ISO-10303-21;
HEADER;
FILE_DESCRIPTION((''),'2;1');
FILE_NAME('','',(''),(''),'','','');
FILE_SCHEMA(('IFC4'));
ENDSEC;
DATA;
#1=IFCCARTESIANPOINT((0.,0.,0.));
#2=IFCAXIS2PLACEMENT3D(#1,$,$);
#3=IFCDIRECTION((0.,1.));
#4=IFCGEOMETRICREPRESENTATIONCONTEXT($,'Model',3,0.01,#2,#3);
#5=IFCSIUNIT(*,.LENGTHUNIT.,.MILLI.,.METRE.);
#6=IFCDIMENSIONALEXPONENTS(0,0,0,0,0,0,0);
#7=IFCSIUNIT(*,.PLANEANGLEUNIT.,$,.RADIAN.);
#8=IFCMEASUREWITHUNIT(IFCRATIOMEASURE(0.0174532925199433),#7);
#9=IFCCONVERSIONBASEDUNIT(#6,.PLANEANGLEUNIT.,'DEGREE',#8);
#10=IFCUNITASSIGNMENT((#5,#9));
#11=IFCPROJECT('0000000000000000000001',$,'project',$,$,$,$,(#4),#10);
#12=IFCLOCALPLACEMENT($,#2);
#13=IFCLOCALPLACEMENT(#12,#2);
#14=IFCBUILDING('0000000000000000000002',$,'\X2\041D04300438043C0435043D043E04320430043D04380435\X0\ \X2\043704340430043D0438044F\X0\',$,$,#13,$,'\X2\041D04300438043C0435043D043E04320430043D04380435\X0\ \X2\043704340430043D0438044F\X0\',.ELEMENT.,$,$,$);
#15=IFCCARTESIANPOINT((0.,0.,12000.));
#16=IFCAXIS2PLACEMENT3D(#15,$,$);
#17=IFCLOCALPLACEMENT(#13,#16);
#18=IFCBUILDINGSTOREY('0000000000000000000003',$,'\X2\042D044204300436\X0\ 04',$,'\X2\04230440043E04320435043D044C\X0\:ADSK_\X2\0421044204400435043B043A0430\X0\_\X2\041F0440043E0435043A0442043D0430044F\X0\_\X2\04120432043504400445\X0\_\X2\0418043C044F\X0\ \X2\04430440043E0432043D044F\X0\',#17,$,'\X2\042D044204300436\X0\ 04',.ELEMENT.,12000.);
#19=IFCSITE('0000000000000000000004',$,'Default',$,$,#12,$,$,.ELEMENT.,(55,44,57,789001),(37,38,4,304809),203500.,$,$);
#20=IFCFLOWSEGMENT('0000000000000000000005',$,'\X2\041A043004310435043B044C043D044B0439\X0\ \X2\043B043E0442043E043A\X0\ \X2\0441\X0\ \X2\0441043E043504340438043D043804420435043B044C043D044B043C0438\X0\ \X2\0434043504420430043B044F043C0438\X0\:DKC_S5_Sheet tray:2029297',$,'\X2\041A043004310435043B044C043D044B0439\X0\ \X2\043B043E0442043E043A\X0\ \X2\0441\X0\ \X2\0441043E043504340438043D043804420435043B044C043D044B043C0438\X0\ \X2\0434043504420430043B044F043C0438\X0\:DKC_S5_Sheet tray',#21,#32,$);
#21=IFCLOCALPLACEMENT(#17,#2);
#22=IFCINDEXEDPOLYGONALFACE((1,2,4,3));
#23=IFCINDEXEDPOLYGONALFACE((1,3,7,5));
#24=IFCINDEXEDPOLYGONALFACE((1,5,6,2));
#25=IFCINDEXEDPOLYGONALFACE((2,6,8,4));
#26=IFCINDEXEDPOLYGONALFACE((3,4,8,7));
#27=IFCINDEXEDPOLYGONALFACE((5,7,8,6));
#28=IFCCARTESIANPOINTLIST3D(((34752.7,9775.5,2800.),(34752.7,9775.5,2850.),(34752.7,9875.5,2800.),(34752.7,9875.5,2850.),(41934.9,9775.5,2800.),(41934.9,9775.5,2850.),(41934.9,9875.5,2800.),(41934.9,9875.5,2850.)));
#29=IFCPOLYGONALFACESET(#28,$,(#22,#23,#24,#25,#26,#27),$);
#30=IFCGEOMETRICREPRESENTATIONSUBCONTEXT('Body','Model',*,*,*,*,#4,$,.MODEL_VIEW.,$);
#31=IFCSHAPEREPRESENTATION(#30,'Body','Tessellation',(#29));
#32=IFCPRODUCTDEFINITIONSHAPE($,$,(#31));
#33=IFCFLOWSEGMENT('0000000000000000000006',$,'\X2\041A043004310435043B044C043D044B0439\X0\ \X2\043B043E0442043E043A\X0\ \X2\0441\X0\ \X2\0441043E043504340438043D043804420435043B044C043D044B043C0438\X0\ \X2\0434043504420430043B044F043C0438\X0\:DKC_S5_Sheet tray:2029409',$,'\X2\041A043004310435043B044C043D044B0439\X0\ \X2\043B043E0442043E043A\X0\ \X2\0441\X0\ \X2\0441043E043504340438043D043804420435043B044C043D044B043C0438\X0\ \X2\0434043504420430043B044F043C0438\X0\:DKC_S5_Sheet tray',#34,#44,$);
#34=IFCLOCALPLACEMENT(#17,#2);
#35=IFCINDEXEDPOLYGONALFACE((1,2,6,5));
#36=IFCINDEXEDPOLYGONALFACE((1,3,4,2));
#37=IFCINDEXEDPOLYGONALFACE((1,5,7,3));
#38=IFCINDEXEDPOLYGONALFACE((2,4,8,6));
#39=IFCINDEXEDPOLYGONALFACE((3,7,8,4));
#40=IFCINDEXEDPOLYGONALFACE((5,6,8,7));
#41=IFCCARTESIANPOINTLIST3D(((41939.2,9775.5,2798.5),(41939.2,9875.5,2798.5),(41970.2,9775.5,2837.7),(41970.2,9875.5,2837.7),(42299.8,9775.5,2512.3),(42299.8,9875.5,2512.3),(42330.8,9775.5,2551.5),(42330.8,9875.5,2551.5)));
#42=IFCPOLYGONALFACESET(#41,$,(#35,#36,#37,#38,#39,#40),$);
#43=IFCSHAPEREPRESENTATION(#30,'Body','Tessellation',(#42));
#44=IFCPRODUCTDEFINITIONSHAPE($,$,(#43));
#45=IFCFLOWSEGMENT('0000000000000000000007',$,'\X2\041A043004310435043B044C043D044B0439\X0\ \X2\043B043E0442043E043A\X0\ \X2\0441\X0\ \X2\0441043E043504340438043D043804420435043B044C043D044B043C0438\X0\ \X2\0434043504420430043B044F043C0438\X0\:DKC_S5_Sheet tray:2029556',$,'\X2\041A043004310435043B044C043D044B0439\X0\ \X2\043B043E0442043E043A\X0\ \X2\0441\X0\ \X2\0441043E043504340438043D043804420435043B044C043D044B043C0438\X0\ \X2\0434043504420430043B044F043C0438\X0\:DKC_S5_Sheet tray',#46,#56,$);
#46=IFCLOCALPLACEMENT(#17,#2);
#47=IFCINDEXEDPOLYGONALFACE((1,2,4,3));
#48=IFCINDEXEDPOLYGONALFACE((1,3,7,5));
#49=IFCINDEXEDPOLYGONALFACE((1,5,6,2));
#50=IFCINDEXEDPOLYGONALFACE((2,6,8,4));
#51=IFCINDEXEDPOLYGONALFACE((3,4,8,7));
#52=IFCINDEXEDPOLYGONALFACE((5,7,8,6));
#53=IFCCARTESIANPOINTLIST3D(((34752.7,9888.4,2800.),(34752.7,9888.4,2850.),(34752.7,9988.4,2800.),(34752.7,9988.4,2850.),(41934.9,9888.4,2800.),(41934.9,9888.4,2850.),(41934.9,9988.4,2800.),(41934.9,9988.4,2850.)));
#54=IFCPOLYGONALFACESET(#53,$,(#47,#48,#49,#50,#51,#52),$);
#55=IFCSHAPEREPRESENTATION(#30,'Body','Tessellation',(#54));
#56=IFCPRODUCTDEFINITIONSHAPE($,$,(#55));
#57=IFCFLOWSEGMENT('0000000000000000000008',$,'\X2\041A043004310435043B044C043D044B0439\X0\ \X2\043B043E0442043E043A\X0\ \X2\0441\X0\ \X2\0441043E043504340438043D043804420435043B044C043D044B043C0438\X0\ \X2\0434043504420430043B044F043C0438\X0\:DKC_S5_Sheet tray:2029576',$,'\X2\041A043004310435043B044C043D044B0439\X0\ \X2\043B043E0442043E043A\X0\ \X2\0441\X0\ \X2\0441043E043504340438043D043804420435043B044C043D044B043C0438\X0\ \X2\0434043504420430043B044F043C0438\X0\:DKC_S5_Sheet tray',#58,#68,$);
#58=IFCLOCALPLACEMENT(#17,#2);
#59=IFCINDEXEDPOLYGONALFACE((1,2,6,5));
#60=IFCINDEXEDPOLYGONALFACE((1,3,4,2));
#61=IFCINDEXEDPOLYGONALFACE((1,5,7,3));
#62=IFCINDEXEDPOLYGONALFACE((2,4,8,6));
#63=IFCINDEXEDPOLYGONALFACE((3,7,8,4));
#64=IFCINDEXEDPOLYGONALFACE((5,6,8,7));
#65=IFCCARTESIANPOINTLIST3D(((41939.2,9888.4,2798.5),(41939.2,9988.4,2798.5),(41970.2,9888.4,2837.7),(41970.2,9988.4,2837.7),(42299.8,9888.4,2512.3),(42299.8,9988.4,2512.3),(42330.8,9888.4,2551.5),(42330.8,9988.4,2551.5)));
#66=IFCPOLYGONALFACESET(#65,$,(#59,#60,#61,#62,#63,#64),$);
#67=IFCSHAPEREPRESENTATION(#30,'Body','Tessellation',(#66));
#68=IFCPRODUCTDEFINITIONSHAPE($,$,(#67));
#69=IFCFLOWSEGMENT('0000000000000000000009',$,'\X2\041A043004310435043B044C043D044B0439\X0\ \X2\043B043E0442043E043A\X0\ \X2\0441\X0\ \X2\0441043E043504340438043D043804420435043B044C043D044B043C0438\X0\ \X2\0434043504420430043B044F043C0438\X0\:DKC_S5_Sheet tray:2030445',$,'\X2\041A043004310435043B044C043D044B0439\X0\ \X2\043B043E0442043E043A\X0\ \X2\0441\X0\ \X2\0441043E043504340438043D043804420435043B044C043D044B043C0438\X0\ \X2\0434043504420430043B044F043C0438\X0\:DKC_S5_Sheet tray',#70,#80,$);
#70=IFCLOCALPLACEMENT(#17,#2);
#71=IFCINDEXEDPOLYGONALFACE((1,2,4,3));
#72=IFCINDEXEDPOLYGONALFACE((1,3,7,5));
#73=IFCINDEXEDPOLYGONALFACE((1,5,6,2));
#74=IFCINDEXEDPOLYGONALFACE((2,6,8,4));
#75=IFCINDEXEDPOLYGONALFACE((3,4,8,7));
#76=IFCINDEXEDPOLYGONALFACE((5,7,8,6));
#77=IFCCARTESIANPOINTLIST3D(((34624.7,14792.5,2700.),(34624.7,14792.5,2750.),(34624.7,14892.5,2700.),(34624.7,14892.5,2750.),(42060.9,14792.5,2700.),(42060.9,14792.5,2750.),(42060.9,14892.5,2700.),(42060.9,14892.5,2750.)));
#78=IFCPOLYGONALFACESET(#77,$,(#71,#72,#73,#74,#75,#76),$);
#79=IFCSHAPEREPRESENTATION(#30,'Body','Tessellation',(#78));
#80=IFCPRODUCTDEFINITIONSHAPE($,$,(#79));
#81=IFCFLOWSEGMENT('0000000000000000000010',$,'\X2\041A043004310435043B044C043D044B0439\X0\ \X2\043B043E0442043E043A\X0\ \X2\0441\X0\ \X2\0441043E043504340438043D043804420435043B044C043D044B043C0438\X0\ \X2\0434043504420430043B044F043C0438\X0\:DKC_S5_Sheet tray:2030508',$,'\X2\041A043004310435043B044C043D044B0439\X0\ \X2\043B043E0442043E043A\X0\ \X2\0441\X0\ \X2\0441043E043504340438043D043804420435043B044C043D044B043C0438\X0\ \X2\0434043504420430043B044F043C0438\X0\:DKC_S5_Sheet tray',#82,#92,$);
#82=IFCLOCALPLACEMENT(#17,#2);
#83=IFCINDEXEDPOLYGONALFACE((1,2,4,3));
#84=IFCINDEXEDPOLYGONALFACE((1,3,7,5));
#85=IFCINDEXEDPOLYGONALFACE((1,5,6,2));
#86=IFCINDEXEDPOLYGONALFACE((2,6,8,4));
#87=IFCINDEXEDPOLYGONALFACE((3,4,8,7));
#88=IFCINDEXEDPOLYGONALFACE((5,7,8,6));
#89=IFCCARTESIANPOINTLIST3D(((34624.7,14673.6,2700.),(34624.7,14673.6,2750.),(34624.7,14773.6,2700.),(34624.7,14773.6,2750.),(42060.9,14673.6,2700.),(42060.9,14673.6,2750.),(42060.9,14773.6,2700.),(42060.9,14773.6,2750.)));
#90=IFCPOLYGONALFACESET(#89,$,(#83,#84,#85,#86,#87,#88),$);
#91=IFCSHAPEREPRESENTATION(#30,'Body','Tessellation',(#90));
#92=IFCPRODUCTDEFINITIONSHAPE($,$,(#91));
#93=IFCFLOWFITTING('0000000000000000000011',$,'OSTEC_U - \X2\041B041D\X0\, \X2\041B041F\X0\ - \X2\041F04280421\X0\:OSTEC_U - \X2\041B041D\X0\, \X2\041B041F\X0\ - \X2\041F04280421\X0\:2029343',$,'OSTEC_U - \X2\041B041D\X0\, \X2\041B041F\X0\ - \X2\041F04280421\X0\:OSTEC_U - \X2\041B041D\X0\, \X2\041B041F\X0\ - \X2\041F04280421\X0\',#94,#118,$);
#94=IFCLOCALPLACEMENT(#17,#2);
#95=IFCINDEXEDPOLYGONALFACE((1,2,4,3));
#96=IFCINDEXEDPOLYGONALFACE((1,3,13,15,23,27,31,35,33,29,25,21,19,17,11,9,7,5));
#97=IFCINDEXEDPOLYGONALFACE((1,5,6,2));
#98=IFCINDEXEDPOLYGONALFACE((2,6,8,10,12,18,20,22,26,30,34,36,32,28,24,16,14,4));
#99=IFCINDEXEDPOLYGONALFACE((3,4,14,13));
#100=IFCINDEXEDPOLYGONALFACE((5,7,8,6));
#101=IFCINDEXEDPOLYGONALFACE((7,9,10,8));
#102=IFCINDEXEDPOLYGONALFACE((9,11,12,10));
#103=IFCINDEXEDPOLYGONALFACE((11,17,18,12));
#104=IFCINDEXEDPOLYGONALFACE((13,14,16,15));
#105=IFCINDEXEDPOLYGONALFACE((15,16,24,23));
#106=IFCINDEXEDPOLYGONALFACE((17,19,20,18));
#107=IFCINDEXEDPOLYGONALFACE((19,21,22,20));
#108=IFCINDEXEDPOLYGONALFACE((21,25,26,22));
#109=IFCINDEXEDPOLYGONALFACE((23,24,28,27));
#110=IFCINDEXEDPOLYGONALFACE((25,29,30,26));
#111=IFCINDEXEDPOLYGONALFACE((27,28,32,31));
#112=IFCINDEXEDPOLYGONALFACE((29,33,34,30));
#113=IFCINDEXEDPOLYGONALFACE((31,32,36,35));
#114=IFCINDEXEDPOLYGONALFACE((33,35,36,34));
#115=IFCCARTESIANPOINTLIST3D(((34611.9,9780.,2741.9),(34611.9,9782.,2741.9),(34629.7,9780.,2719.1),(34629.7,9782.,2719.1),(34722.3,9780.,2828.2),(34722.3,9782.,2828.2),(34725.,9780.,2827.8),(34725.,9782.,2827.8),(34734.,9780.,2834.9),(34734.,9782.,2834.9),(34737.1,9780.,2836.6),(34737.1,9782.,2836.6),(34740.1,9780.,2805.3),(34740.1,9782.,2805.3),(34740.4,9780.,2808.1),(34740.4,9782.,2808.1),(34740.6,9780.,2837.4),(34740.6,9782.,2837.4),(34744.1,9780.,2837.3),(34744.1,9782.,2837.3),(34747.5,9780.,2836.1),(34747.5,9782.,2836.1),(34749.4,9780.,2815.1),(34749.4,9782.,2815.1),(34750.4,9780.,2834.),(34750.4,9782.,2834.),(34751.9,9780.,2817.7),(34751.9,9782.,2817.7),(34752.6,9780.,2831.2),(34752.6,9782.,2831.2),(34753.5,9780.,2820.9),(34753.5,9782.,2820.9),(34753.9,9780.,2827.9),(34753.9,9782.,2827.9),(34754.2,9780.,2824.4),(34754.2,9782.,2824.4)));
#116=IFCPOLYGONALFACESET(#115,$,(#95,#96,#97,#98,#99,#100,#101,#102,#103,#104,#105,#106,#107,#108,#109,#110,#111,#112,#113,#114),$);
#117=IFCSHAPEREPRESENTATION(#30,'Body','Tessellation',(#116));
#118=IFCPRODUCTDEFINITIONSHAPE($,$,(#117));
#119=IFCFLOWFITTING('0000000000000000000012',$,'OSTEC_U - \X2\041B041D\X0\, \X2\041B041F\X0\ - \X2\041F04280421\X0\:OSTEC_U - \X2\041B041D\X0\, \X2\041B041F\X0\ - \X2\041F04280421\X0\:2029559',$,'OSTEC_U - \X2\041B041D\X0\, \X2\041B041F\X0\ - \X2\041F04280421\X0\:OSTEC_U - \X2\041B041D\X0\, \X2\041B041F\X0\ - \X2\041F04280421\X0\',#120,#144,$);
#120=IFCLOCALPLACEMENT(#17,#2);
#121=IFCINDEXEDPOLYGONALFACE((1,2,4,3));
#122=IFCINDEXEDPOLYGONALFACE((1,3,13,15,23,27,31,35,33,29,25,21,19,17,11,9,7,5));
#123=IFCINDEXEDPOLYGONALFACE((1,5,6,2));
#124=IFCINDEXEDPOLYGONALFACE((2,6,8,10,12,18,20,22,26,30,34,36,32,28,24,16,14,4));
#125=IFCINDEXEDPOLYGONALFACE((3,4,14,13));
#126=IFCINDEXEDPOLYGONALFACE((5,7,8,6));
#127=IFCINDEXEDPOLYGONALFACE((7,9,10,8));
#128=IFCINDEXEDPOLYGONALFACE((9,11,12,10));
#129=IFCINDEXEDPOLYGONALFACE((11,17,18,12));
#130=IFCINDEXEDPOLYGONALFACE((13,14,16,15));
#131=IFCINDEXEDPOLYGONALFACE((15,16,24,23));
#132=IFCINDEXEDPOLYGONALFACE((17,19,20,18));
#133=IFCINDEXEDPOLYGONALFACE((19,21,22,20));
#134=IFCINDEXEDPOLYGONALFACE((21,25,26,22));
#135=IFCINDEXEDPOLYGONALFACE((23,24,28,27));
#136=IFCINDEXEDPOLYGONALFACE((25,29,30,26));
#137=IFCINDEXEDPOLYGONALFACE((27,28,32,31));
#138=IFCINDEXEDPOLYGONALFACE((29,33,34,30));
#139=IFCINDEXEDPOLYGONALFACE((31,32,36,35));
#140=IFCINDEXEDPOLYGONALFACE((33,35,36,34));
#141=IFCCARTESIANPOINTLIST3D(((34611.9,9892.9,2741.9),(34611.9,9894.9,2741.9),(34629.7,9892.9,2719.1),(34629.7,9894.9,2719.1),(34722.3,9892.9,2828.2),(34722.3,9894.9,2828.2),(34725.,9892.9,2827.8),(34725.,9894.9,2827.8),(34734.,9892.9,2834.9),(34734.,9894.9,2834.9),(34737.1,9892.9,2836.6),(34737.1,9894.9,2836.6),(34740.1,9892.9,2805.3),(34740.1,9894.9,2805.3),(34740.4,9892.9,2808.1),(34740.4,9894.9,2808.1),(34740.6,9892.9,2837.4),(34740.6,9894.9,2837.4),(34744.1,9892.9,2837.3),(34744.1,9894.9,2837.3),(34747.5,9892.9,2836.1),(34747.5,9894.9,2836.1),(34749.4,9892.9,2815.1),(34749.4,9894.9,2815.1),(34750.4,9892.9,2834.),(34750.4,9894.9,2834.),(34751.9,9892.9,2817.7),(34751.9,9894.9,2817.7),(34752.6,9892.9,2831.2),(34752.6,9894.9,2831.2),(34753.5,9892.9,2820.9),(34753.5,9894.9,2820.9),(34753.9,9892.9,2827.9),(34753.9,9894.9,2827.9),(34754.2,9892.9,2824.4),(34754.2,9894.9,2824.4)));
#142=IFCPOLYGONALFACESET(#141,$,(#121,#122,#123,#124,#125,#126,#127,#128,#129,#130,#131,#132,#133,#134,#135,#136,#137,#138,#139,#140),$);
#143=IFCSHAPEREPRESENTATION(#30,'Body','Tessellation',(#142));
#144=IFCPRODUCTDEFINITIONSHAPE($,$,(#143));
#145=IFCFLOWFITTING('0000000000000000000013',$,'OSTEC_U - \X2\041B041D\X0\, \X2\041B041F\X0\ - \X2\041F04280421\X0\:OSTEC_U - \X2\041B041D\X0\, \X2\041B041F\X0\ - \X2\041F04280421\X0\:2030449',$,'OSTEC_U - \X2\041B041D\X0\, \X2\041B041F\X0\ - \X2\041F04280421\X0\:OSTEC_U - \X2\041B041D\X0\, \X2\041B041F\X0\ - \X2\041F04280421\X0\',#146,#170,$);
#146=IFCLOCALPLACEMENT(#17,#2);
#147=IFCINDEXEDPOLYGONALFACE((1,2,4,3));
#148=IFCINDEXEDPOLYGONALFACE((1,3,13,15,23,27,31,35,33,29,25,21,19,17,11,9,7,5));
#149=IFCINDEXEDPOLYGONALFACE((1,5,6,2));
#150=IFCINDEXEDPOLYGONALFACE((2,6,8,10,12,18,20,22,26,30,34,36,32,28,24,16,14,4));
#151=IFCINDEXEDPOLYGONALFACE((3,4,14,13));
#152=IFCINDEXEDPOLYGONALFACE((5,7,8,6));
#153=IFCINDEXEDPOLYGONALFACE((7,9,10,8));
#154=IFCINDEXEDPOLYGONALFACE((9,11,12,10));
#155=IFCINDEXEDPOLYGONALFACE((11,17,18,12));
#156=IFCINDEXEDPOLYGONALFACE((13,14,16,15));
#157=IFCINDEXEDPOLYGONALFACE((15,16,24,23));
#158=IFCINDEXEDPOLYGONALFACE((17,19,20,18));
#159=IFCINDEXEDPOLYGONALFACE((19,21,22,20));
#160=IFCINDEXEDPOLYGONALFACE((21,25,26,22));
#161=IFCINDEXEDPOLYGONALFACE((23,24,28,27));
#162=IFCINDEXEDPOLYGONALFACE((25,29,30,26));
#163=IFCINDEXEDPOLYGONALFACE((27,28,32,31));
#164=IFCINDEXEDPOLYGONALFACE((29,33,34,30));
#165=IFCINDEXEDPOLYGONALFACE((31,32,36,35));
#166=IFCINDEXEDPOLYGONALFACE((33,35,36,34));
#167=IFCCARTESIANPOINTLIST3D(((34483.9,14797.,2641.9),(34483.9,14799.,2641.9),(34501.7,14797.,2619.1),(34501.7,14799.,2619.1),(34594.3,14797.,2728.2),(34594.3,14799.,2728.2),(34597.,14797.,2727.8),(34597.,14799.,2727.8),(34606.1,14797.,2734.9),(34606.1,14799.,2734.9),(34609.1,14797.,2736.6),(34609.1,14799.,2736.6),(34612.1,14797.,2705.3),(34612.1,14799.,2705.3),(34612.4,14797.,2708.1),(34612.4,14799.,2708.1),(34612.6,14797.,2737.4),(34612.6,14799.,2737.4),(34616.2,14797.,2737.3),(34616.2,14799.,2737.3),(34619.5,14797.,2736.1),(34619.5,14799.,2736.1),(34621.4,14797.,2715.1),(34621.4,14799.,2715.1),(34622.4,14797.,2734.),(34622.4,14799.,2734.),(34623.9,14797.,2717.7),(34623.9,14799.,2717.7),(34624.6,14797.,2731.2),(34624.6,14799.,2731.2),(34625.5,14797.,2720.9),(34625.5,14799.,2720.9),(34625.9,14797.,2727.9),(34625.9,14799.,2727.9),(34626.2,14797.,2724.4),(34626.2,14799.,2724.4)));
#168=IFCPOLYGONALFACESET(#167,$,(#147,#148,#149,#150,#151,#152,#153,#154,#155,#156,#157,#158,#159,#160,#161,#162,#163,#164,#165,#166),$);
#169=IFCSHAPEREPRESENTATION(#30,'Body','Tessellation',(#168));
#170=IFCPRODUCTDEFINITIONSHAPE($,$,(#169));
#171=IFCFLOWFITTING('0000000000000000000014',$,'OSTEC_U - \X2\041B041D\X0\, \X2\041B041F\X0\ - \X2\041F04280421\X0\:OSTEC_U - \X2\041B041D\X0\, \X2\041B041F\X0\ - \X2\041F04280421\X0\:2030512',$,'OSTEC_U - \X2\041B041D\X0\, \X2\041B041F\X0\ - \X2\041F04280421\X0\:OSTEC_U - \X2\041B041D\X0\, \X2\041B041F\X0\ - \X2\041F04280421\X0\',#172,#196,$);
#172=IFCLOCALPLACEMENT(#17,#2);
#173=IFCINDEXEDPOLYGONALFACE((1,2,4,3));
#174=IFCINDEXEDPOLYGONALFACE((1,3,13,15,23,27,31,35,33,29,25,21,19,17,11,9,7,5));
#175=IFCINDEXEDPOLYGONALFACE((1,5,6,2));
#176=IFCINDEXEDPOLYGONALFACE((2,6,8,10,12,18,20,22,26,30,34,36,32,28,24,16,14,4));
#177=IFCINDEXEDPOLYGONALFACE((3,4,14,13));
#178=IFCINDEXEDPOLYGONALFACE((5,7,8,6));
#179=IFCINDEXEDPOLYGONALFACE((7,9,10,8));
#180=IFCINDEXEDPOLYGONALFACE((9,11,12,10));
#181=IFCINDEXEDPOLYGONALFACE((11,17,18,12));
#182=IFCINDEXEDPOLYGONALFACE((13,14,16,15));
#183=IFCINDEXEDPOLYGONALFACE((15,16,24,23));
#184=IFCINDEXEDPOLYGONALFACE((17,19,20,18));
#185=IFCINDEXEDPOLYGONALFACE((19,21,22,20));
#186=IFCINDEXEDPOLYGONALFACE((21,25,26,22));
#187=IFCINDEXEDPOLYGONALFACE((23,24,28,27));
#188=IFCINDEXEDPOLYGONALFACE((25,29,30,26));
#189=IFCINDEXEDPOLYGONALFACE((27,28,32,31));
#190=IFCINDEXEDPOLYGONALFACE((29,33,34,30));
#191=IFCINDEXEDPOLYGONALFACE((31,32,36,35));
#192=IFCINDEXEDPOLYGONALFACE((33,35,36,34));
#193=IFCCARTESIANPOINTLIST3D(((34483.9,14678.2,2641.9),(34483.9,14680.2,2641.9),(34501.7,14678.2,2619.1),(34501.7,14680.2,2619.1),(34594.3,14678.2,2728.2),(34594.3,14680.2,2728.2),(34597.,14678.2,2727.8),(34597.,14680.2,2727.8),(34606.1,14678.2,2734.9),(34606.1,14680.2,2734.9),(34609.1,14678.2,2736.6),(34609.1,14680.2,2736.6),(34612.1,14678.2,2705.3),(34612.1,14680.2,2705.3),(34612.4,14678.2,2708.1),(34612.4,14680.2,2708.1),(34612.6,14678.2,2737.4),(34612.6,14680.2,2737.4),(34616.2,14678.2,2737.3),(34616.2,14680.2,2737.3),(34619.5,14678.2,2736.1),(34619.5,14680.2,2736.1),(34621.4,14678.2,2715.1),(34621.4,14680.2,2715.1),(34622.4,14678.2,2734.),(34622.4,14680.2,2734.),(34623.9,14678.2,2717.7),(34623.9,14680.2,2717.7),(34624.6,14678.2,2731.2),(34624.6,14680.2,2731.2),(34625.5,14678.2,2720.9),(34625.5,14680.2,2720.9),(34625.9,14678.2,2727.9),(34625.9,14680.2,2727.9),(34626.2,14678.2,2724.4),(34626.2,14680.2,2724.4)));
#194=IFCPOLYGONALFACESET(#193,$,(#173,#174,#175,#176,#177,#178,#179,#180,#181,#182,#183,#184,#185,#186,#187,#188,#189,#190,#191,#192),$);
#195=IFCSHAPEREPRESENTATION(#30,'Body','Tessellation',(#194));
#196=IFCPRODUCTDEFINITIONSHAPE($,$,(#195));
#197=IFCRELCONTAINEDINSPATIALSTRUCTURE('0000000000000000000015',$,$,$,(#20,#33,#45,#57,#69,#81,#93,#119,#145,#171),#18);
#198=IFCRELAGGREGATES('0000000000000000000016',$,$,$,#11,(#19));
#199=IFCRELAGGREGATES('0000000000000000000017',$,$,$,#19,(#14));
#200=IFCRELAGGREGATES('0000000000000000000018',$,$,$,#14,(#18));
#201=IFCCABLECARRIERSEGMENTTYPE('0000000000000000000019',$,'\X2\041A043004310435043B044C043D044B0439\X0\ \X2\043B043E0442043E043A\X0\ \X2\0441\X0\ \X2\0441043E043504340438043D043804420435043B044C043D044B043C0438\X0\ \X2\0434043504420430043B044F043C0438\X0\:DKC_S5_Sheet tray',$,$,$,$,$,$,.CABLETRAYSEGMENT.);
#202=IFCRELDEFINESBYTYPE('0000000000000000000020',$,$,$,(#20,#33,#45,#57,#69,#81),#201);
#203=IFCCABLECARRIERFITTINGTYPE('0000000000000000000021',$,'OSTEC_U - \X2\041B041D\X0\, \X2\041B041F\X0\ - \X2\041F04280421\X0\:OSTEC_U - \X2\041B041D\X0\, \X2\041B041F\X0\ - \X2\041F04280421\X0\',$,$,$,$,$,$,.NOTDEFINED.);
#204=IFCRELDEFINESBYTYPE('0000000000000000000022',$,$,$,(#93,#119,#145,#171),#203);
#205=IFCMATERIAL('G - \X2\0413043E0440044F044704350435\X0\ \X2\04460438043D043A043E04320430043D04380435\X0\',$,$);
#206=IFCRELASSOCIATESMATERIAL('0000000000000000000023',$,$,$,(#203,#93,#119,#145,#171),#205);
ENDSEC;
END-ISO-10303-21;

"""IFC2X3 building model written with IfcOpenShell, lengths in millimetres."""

from ifc_helpers import new_model, entity, si_unit, converted_unit, direction, frame, frame_2d, origin, place, context, subcontext, project, spatial, polyline, circle_curve, parameter, trimmed, segment, composite_curve, rectangle, outline, extrude, source, transform, mapped, material, type_object, type_shapes, element, save


model = new_model("IFC2X3")

# Units and contexts
model_context = context("Model", 3, precision=0.01, world=origin(), true_north=direction((0.0, 1.0)))
body_context = subcontext(model_context, "Body", "Model", "MODEL_VIEW")
ifc_project = project(units=[si_unit("LENGTHUNIT", "METRE", prefix="MILLI"), converted_unit("PLANEANGLEUNIT", "DEGREE", entity("IfcRatioMeasure", 0.0174532925199433), si_unit("PLANEANGLEUNIT", "RADIAN"), dimensions=[0, 0, 0, 0, 0, 0, 0])], contexts=[model_context])

# Site, building, storey
site_placement = place(None, frame((0.0, 0.0, 0.0)))
site = spatial("IfcSite", under=ifc_project, at=site_placement, Name="Default", CompositionType="ELEMENT", RefLatitude=(55, 44, 57, 789001), RefLongitude=(37, 38, 4, 304809), RefElevation=203500.0)
building_placement = place(site_placement, origin())
building = spatial("IfcBuilding", under=site, at=building_placement, Name="Наименование здания", LongName="Наименование здания", CompositionType="ELEMENT")
storey_placement = place(building_placement, frame((0.0, 0.0, 12000.0)))
storey = spatial("IfcBuildingStorey", under=building, at=storey_placement, Name="Этаж 04", ObjectType="Уровень:ADSK_Стрелка_Проектная_Вверх_Имя уровня", LongName="Этаж 04", CompositionType="ELEMENT", Elevation=12000.0)

# Flow segments
cable_carrier_segment_type = type_object("IfcCableCarrierSegmentType", Name="Кабельный лоток с соединительными деталями:DKC_S5_Sheet tray", PredefinedType="CABLETRAYSEGMENT")
flow_segment_1_placement = place(storey_placement, frame((34752.7, 9775.5, 2800.0)))
element("IfcFlowSegment", 1, at=flow_segment_1_placement, inside=storey, type_object=cable_carrier_segment_type, Name="Кабельный лоток с соединительными деталями:DKC_S5_Sheet tray:2029297", ObjectType="Кабельный лоток с соединительными деталями:DKC_S5_Sheet tray", context=body_context, shape_type="SweptSolid", body=[
    extrude(rectangle(XDim=7182.2, YDim=100.0, at=frame_2d((0.0, 0.0), x_axis=(1.0, 0.0))), frame((3591.1, 50.0, 0.0)), (0.0, 0.0, 1.0), 50.0),
])
flow_segment_2_placement = place(storey_placement, frame((41939.2, 9775.5, 2512.3)))
element("IfcFlowSegment", 2, at=flow_segment_2_placement, inside=storey, type_object=cable_carrier_segment_type, Name="Кабельный лоток с соединительными деталями:DKC_S5_Sheet tray:2029409", ObjectType="Кабельный лоток с соединительными деталями:DKC_S5_Sheet tray", context=body_context, shape_type="SweptSolid", body=[
    extrude(rectangle(XDim=50.0, YDim=100.0, at=frame_2d((0.0, 0.0), x_axis=(1.0, 0.0))), frame((15.5, 50.0, 305.8), z_axis=(0.783284, 0.0, -0.621664), x_axis=(0.621664, 0.0, 0.783284)), (0.0, 0.0, 1.0), 460.4),
])
flow_segment_3_placement = place(storey_placement, frame((34752.7, 9888.4, 2800.0)))
element("IfcFlowSegment", 3, at=flow_segment_3_placement, inside=storey, type_object=cable_carrier_segment_type, Name="Кабельный лоток с соединительными деталями:DKC_S5_Sheet tray:2029556", ObjectType="Кабельный лоток с соединительными деталями:DKC_S5_Sheet tray", context=body_context, shape_type="SweptSolid", body=[
    extrude(rectangle(XDim=7182.2, YDim=100.0, at=frame_2d((0.0, 0.0), x_axis=(1.0, 0.0))), frame((3591.1, 50.0, 0.0)), (0.0, 0.0, 1.0), 50.0),
])
flow_segment_4_placement = place(storey_placement, frame((41939.2, 9888.4, 2512.3)))
element("IfcFlowSegment", 4, at=flow_segment_4_placement, inside=storey, type_object=cable_carrier_segment_type, Name="Кабельный лоток с соединительными деталями:DKC_S5_Sheet tray:2029576", ObjectType="Кабельный лоток с соединительными деталями:DKC_S5_Sheet tray", context=body_context, shape_type="SweptSolid", body=[
    extrude(rectangle(XDim=50.0, YDim=100.0, at=frame_2d((0.0, 0.0), x_axis=(1.0, 0.0))), frame((15.5, 50.0, 305.8), z_axis=(0.783284, 0.0, -0.621664), x_axis=(0.621664, 0.0, 0.783284)), (0.0, 0.0, 1.0), 460.4),
])
flow_segment_5_placement = place(storey_placement, frame((34624.7, 14792.5, 2700.0)))
element("IfcFlowSegment", 5, at=flow_segment_5_placement, inside=storey, type_object=cable_carrier_segment_type, Name="Кабельный лоток с соединительными деталями:DKC_S5_Sheet tray:2030445", ObjectType="Кабельный лоток с соединительными деталями:DKC_S5_Sheet tray", context=body_context, shape_type="SweptSolid", body=[
    extrude(rectangle(XDim=7436.2, YDim=100.0, at=frame_2d((0.0, 0.0), x_axis=(1.0, 0.0))), frame((3718.1, 50.0, 0.0)), (0.0, 0.0, 1.0), 50.0),
])
flow_segment_6_placement = place(storey_placement, frame((34624.7, 14673.6, 2700.0)))
element("IfcFlowSegment", 6, at=flow_segment_6_placement, inside=storey, type_object=cable_carrier_segment_type, Name="Кабельный лоток с соединительными деталями:DKC_S5_Sheet tray:2030508", ObjectType="Кабельный лоток с соединительными деталями:DKC_S5_Sheet tray", context=body_context, shape_type="SweptSolid", body=[
    extrude(rectangle(XDim=7436.2, YDim=100.0, at=frame_2d((0.0, 0.0), x_axis=(1.0, 0.0))), frame((3718.1, 50.0, 0.0)), (0.0, 0.0, 1.0), 50.0),
])

# Flow fittings
ifc_material = material(Name="G - Горячее цинкование")
cable_carrier_fitting_type_1 = type_object("IfcCableCarrierFittingType", Name="OSTEC_U - ЛН, ЛП - ПШС:OSTEC_U - ЛН, ЛП - ПШС", PredefinedType="NOTDEFINED", material=ifc_material)
shared_shape_1 = source(origin(), body_context, "Body", "SweptSolid", [
    extrude(outline(composite_curve([segment(trimmed(circle_curve(frame_2d((-44.6, 0.0), x_axis=(1.0, 0.0)), 12.5), [parameter(90.0)], [parameter(270.0)], True, "PARAMETER"), True, "CONTINUOUS"), segment(polyline([(-44.6, -12.5), (-33.1, -12.5)]), True, "CONTINUOUS"), segment(polyline([(-33.1, -12.5), (-31.2, -14.5)]), True, "CONTINUOUS"), segment(polyline([(-31.2, -14.5), (108.9, -14.5)]), True, "CONTINUOUS"), segment(polyline([(108.9, -14.5), (108.9, 14.5)]), True, "CONTINUOUS"), segment(polyline([(108.9, 14.5), (-31.2, 14.5)]), True, "CONTINUOUS"), segment(polyline([(-31.2, 14.5), (-33.1, 12.5)]), True, "CONTINUOUS"), segment(polyline([(-33.1, 12.5), (-44.6, 12.5)]), True, "CONTINUOUS")], self_intersect=False)), frame((44.6, 0.0, 0.0), z_axis=(0.0, 0.0, -1.0), x_axis=(1.0, 0.0, 0.0)), (0.0, 0.0, -1.0), 2.0),
])
type_shapes(cable_carrier_fitting_type_1, [shared_shape_1])
for number, where, z_axis, x_axis, name in (
    (7, (34741.7, 9782.0, 2825.0), (0.0, -1.0, 0.0), (-0.788011, 0.0, -0.615661), "OSTEC_U - ЛН, ЛП - ПШС:OSTEC_U - ЛН, ЛП - ПШС:2029343"),
    (8, (34741.7, 9894.9, 2825.0), (0.0, -1.0, 0.0), (-0.788011, 0.0, -0.615661), "OSTEC_U - ЛН, ЛП - ПШС:OSTEC_U - ЛН, ЛП - ПШС:2029559"),
    (9, (34613.7, 14799.0, 2725.0), (0.0, -1.0, 0.0), (-0.788011, 0.0, -0.615661), "OSTEC_U - ЛН, ЛП - ПШС:OSTEC_U - ЛН, ЛП - ПШС:2030449"),
    (10, (34613.7, 14680.2, 2725.0), (0.0, -1.0, 0.0), (-0.788011, 0.0, -0.615661), "OSTEC_U - ЛН, ЛП - ПШС:OSTEC_U - ЛН, ЛП - ПШС:2030512"),
):
    element("IfcFlowFitting", number, at=place(storey_placement, frame(where, z_axis=z_axis, x_axis=x_axis)), inside=storey, type_object=cable_carrier_fitting_type_1, material=ifc_material, Name=name, ObjectType="OSTEC_U - ЛН, ЛП - ПШС:OSTEC_U - ЛН, ЛП - ПШС", context=body_context, shape_type="MappedRepresentation", body=[
        mapped(shared_shape_1, transform((0.0, 0.0, 0.0), scale=1.0)),
    ])

save(model, "model.ifc")
